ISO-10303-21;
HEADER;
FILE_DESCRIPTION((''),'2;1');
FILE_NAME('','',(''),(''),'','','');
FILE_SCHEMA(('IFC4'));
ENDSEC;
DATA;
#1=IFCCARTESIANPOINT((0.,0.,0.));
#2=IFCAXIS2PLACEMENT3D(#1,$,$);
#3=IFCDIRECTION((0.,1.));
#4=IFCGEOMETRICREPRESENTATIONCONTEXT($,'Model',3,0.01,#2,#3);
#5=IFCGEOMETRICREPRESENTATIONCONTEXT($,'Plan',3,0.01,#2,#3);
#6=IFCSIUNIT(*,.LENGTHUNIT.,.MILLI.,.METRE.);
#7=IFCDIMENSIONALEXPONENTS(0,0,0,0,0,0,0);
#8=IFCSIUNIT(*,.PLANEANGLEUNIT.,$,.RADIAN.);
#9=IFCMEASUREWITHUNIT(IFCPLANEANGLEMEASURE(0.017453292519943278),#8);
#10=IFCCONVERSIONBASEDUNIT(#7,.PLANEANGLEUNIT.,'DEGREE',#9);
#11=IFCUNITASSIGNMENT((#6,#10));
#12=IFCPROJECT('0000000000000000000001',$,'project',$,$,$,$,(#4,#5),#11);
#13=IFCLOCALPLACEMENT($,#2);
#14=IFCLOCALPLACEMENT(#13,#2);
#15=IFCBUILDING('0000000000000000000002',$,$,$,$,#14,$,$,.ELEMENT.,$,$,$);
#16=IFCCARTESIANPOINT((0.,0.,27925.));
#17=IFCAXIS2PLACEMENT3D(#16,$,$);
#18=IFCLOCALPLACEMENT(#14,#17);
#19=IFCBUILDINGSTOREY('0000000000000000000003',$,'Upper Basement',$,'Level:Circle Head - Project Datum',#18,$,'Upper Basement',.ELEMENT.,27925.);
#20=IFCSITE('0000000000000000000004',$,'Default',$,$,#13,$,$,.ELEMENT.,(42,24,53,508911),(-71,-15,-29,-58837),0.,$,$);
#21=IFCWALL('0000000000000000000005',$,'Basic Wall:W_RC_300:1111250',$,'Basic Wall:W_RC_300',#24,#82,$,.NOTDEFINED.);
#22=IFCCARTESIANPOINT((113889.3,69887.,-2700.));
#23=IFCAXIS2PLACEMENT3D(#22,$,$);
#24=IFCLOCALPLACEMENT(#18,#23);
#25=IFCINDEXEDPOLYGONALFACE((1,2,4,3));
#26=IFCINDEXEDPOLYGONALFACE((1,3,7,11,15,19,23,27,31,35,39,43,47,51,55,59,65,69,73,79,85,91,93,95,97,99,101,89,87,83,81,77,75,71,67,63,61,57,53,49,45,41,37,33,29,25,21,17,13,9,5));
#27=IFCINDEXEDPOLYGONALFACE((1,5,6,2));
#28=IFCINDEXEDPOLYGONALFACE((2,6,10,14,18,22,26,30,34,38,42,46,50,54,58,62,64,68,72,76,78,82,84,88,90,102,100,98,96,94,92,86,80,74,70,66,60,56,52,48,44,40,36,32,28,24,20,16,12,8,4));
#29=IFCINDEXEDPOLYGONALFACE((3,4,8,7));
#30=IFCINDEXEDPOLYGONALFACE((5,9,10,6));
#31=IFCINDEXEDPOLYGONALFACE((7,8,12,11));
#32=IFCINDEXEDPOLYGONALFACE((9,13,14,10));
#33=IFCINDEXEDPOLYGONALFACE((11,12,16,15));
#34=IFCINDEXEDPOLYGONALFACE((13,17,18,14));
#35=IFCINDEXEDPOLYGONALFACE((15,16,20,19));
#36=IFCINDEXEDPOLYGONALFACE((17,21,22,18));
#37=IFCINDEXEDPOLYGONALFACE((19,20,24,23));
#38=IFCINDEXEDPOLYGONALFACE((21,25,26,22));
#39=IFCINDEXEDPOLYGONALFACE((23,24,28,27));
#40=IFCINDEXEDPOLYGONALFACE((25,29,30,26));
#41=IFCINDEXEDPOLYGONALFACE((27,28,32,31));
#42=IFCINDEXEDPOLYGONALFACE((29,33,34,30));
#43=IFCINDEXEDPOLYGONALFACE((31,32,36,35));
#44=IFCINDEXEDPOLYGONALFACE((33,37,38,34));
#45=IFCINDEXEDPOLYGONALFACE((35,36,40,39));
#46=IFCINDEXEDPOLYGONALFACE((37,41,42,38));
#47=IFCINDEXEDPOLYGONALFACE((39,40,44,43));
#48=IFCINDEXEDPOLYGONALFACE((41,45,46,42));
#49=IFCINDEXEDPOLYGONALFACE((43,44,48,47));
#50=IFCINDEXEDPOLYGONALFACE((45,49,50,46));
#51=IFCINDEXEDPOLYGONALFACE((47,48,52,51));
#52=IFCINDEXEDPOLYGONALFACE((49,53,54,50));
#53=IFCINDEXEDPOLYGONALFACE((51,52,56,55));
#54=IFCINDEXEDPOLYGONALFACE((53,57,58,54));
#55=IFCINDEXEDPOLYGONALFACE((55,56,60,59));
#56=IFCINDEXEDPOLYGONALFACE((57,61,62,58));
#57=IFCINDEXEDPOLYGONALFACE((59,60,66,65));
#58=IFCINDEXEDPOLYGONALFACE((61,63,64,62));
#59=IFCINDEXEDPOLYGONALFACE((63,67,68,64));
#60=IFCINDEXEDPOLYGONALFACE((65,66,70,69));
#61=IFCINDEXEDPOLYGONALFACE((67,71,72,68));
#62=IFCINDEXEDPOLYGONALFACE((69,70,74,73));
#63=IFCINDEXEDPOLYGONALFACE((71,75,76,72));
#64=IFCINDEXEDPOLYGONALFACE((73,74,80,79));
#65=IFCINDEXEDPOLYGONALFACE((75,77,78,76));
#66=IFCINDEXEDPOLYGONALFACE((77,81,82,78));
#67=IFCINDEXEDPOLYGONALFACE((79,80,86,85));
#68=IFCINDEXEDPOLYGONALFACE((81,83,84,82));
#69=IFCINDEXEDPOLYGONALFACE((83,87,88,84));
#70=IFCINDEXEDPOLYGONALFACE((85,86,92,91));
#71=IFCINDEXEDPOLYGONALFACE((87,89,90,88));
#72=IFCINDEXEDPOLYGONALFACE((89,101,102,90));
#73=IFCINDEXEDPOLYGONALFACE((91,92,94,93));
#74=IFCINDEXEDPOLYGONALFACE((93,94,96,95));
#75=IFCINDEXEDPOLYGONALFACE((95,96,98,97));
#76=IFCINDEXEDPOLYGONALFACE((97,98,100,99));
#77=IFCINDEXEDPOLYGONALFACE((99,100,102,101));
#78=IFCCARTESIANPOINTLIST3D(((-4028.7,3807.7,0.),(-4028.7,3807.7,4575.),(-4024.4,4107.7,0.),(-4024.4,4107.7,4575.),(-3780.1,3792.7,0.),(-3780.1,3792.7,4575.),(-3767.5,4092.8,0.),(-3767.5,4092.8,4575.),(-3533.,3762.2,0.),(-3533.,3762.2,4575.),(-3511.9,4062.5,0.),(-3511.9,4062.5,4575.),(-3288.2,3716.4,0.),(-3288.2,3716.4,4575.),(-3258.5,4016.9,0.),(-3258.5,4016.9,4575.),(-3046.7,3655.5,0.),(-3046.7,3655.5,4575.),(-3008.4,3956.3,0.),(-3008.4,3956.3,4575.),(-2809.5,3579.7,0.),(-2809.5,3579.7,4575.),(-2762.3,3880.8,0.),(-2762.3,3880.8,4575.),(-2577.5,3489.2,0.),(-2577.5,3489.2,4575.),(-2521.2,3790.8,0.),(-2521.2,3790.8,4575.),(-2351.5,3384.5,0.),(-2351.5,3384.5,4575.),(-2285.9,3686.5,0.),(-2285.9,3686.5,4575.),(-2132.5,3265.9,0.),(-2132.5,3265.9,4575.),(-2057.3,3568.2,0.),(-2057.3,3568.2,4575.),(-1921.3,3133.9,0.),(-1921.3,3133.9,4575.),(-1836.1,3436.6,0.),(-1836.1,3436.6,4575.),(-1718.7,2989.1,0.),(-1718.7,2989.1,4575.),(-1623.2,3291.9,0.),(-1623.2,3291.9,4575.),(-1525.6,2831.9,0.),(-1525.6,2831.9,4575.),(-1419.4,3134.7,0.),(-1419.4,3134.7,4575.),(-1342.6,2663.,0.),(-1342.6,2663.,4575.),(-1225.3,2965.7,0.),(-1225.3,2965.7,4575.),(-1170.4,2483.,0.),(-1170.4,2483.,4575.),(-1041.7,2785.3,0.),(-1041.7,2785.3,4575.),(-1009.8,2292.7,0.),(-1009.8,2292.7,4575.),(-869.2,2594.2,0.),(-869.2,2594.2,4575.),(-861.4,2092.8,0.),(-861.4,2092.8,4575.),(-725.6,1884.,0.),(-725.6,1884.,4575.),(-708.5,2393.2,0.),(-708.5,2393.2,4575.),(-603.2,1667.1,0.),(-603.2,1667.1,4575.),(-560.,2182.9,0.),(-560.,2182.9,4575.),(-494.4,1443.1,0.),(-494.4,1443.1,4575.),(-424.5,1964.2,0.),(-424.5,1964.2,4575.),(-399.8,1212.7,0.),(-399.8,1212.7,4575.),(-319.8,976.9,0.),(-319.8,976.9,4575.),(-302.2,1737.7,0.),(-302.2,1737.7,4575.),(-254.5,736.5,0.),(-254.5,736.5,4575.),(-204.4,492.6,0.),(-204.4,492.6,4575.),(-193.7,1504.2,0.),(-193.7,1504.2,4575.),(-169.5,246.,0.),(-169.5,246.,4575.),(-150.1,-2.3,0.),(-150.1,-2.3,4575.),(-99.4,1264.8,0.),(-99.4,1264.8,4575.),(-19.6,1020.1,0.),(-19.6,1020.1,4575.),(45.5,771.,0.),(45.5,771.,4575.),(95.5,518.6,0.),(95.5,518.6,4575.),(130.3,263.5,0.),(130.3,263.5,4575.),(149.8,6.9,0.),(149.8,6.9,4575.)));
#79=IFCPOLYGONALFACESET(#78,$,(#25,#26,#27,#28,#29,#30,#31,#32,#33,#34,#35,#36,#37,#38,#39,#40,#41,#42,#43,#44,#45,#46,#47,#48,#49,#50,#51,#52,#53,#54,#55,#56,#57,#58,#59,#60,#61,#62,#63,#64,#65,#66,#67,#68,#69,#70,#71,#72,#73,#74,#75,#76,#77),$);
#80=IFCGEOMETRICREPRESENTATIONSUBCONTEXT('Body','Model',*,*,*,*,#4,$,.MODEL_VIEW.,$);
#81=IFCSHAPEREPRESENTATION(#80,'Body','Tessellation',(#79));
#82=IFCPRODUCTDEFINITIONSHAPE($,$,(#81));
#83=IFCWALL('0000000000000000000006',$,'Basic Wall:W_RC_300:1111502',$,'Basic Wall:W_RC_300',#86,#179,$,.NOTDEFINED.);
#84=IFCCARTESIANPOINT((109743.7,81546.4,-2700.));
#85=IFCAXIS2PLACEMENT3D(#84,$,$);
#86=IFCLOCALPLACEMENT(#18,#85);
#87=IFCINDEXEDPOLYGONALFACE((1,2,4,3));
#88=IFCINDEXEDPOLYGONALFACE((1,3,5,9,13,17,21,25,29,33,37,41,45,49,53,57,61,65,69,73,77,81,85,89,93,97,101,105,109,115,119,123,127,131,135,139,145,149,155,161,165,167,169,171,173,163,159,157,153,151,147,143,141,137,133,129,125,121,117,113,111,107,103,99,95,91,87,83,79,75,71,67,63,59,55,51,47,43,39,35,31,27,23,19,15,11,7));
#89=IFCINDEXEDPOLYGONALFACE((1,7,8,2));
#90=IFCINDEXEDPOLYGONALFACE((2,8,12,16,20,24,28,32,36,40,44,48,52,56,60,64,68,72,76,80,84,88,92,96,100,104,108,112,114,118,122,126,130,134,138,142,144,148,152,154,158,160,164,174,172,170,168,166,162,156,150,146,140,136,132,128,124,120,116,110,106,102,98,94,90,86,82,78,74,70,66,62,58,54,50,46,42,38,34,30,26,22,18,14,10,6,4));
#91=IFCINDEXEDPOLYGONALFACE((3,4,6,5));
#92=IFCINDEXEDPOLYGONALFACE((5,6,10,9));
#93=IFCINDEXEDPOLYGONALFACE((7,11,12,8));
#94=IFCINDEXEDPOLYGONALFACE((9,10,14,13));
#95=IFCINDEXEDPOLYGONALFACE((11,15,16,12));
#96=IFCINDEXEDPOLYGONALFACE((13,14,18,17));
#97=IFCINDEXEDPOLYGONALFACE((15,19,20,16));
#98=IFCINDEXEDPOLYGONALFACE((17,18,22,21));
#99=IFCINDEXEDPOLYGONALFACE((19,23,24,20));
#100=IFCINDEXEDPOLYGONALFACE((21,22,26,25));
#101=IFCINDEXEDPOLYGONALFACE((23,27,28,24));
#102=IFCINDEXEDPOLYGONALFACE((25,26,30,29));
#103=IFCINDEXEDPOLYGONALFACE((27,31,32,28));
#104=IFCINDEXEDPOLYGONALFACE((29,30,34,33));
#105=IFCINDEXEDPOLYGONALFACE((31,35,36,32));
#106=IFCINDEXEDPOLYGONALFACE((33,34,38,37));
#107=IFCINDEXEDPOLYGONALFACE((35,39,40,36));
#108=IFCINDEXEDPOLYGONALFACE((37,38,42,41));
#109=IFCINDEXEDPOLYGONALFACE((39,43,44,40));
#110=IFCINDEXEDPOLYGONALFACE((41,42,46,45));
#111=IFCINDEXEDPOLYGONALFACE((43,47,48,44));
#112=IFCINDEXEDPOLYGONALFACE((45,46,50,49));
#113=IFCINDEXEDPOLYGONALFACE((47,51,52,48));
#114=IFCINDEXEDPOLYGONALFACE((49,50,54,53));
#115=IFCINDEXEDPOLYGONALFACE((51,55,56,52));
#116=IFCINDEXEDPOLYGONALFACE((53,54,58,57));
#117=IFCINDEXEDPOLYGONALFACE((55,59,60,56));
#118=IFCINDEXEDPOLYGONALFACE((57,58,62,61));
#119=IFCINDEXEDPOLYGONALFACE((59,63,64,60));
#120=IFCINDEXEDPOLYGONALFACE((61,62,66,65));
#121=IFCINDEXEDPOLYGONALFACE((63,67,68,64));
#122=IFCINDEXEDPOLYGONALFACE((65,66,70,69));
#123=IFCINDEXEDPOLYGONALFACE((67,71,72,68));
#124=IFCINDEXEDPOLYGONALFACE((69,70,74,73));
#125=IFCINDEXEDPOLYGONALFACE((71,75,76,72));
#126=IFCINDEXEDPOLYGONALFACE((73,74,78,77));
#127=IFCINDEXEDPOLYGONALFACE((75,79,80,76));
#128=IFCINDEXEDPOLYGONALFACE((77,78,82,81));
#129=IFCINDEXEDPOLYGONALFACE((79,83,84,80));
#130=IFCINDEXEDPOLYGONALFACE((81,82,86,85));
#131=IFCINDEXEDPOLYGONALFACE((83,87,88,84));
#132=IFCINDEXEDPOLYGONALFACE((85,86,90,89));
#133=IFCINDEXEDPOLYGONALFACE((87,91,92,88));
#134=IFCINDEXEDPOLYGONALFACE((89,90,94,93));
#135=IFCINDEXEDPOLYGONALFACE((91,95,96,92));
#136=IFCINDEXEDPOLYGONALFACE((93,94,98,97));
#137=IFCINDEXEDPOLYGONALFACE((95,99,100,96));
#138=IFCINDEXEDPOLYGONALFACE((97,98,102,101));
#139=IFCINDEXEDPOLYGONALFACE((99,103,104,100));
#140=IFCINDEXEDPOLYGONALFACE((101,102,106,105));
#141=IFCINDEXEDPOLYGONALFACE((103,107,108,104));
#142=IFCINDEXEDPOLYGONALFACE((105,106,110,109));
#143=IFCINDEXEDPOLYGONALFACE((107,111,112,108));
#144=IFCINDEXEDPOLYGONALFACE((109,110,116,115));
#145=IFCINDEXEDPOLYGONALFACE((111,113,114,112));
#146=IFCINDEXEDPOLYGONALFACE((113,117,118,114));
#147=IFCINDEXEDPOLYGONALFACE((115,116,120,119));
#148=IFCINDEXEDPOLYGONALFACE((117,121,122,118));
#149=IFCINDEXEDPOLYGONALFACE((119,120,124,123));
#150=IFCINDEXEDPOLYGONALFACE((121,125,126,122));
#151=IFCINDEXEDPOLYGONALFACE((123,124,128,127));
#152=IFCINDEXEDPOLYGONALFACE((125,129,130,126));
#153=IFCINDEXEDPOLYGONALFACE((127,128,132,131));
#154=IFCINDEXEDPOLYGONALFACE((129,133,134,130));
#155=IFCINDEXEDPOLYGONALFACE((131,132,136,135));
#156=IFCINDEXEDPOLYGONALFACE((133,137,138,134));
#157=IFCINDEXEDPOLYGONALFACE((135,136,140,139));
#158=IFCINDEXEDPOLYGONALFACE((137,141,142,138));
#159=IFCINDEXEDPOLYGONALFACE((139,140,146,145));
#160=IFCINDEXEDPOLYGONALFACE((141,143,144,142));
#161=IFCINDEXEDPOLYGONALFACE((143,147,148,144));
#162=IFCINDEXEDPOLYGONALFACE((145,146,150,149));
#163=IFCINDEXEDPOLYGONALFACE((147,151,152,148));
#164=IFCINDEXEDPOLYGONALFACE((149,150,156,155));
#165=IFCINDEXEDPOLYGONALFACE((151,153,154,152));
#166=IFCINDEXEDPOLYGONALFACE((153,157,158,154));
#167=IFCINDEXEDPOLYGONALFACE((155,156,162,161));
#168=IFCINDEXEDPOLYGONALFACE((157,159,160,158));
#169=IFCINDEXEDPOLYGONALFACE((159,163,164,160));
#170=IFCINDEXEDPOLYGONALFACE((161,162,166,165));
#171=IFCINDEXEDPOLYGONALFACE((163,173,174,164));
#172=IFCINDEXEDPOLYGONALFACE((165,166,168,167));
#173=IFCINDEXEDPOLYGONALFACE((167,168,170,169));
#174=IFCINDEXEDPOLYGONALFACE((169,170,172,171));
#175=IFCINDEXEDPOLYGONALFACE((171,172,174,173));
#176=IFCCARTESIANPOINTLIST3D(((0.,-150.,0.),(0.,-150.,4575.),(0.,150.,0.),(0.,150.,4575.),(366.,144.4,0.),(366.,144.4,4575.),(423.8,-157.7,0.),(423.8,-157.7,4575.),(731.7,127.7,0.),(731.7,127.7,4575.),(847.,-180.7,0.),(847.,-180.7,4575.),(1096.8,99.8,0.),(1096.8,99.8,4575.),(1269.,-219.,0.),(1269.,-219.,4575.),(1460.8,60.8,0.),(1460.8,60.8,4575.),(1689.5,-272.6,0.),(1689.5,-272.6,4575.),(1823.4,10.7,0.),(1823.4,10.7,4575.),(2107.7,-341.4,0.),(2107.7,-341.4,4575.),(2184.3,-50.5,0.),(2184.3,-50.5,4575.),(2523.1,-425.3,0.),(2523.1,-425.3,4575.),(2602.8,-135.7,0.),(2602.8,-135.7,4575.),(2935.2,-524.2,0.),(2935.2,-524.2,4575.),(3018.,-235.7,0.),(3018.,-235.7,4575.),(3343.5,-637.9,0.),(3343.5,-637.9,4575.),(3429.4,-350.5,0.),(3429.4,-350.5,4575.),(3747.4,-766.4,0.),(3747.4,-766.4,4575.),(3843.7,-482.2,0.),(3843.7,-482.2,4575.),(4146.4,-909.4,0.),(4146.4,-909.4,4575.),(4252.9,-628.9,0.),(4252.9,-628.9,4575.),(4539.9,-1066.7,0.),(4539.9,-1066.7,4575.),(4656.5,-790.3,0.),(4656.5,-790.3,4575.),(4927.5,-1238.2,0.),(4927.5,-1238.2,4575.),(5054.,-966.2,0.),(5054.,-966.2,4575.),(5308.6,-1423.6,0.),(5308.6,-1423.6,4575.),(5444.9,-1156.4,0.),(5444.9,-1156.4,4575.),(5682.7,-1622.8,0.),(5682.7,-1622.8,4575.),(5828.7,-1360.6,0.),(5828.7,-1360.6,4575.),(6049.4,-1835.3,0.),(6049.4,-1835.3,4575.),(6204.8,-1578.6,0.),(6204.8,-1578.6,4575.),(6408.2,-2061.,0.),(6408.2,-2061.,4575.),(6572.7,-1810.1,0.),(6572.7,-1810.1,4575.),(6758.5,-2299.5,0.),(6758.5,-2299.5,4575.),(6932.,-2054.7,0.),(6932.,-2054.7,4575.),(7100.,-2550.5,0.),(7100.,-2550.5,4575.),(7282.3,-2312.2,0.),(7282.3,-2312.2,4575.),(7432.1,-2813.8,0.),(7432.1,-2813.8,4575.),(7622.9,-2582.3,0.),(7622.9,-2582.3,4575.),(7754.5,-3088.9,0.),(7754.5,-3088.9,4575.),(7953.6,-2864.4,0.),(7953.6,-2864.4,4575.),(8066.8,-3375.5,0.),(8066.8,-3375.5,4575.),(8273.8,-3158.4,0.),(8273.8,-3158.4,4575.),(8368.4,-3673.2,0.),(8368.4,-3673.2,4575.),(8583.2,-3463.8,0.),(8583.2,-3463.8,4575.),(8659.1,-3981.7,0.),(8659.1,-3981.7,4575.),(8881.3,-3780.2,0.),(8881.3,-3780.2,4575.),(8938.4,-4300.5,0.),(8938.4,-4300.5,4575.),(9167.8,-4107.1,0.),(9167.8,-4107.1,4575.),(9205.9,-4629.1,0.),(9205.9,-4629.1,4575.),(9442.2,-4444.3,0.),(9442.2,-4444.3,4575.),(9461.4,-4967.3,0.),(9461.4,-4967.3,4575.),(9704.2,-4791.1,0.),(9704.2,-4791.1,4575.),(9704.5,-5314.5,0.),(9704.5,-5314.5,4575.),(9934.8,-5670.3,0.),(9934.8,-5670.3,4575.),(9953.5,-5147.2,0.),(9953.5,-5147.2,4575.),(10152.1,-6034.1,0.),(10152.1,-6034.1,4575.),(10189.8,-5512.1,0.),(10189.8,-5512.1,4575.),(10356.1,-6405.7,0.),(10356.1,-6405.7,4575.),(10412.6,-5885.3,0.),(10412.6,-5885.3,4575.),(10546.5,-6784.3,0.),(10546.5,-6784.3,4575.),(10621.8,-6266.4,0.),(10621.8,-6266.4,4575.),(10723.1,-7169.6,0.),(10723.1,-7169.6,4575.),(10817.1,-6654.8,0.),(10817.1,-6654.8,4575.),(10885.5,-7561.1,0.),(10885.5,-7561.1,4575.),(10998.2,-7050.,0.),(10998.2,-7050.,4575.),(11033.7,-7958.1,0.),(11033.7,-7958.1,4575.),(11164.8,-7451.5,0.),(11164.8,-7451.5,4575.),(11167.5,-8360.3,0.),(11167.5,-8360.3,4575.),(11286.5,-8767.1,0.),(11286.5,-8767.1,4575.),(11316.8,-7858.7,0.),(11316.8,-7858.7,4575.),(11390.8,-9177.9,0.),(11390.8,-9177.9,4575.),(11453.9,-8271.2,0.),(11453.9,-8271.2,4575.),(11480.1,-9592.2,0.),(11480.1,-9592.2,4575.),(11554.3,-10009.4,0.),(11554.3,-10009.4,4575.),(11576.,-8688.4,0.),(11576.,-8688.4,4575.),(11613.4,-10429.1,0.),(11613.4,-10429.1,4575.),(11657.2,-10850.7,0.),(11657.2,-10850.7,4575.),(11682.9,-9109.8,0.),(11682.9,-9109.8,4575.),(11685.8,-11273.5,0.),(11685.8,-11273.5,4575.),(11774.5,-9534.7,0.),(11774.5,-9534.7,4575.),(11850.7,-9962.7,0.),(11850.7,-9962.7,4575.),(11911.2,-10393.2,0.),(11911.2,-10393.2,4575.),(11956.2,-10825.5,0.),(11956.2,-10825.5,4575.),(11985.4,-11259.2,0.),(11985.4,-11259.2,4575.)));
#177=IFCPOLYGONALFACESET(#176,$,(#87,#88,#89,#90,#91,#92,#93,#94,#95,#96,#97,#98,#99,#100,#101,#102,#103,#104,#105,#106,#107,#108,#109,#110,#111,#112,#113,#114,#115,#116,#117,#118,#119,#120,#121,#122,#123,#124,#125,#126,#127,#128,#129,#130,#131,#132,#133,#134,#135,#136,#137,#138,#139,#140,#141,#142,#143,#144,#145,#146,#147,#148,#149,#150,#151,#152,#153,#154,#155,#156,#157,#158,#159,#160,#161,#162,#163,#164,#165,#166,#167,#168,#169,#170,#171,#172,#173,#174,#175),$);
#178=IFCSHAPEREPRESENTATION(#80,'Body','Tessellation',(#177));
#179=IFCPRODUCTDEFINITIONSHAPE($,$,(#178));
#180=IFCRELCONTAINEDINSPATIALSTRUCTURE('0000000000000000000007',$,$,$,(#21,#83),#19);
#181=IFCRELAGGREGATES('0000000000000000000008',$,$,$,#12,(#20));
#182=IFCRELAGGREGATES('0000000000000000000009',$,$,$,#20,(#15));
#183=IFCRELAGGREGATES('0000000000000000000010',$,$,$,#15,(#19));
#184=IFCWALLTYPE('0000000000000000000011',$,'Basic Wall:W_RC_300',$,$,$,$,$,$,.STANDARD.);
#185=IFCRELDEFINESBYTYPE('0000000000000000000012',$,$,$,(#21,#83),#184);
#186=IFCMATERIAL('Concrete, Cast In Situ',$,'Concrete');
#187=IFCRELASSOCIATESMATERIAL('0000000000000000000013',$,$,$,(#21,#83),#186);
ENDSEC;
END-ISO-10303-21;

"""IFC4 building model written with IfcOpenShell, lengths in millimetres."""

from ifc_helpers import new_model, entity, si_unit, converted_unit, direction, frame, origin, place, context, subcontext, project, spatial, line, arc, indexed_curve, outline, extrude, material, type_object, element, save


model = new_model("IFC4")

# Units and contexts
model_context = context("Model", 3, precision=0.01, world=origin(), true_north=direction((0.0, 1.0)))
plan_context = context("Plan", 3, precision=0.01, world=origin(), true_north=direction((0.0, 1.0)))
body_context = subcontext(model_context, "Body", "Model", "MODEL_VIEW")
ifc_project = project(units=[si_unit("LENGTHUNIT", "METRE", prefix="MILLI"), converted_unit("PLANEANGLEUNIT", "DEGREE", entity("IfcPlaneAngleMeasure", 0.017453292519943278), si_unit("PLANEANGLEUNIT", "RADIAN"), dimensions=[0, 0, 0, 0, 0, 0, 0])], contexts=[model_context, plan_context])

# Site, building, storey
site_placement = place(None, origin())
site = spatial("IfcSite", under=ifc_project, at=site_placement, Name="Default", CompositionType="ELEMENT", RefLatitude=(42, 24, 53, 508911), RefLongitude=(-71, -15, -29, -58837), RefElevation=0.0)
building_placement = place(site_placement, origin())
building = spatial("IfcBuilding", under=site, at=building_placement, CompositionType="ELEMENT")
storey_placement = place(building_placement, frame((0.0, 0.0, 27925.0)))
storey = spatial("IfcBuildingStorey", under=building, at=storey_placement, Name="Upper Basement", ObjectType="Level:Circle Head - Project Datum", LongName="Upper Basement", CompositionType="ELEMENT", Elevation=27925.0)

# Walls
ifc_material_1 = material(Name="Concrete, Cast In Situ", Category="Concrete")
wall_type = type_object("IfcWallType", Name="Basic Wall:W_RC_300", PredefinedType="STANDARD")
wall_1_placement = place(storey_placement, frame((113889.3, 69887.0, -2700.0)))
element("IfcWall", 1, at=wall_1_placement, inside=storey, type_object=wall_type, material=ifc_material_1, Name="Basic Wall:W_RC_300:1111250", ObjectType="Basic Wall:W_RC_300", PredefinedType="NOTDEFINED", context=body_context, shape_type="SweptSolid", body=[
    extrude(outline(indexed_curve([(-4028.7, 3807.7), (-1342.6, 2663.0), (-150.1, -2.3), (149.8, 6.9), (-1132.2, 2876.8), (-4024.4, 4107.7)], segments=[arc(1, 2, 3), line(3, 4), arc(4, 5, 6), line(6, 1)], self_intersect=False)), origin(), (0.0, 0.0, 1.0), 4575.0),
])
wall_2_placement = place(storey_placement, frame((109743.7, 81546.4, -2700.0)))
element("IfcWall", 2, at=wall_2_placement, inside=storey, type_object=wall_type, material=ifc_material_1, Name="Basic Wall:W_RC_300:1111502", ObjectType="Basic Wall:W_RC_300", PredefinedType="NOTDEFINED", context=body_context, shape_type="SweptSolid", body=[
    extrude(outline(indexed_curve([(11985.4, -11259.2), (9442.2, -4444.3), (3429.4, -350.5), (2810.9, -183.9), (2184.3, -50.5), (1096.8, 99.8), (0.0, 150.0), (0.0, -150.0), (8066.8, -3375.5), (11685.8, -11273.5)], segments=[arc(1, 2, 3), arc(3, 4, 5), arc(5, 6, 7), line(7, 8), arc(8, 9, 10), line(10, 1)], self_intersect=False)), origin(), (0.0, 0.0, 1.0), 4575.0),
])

save(model, "model.ifc")
